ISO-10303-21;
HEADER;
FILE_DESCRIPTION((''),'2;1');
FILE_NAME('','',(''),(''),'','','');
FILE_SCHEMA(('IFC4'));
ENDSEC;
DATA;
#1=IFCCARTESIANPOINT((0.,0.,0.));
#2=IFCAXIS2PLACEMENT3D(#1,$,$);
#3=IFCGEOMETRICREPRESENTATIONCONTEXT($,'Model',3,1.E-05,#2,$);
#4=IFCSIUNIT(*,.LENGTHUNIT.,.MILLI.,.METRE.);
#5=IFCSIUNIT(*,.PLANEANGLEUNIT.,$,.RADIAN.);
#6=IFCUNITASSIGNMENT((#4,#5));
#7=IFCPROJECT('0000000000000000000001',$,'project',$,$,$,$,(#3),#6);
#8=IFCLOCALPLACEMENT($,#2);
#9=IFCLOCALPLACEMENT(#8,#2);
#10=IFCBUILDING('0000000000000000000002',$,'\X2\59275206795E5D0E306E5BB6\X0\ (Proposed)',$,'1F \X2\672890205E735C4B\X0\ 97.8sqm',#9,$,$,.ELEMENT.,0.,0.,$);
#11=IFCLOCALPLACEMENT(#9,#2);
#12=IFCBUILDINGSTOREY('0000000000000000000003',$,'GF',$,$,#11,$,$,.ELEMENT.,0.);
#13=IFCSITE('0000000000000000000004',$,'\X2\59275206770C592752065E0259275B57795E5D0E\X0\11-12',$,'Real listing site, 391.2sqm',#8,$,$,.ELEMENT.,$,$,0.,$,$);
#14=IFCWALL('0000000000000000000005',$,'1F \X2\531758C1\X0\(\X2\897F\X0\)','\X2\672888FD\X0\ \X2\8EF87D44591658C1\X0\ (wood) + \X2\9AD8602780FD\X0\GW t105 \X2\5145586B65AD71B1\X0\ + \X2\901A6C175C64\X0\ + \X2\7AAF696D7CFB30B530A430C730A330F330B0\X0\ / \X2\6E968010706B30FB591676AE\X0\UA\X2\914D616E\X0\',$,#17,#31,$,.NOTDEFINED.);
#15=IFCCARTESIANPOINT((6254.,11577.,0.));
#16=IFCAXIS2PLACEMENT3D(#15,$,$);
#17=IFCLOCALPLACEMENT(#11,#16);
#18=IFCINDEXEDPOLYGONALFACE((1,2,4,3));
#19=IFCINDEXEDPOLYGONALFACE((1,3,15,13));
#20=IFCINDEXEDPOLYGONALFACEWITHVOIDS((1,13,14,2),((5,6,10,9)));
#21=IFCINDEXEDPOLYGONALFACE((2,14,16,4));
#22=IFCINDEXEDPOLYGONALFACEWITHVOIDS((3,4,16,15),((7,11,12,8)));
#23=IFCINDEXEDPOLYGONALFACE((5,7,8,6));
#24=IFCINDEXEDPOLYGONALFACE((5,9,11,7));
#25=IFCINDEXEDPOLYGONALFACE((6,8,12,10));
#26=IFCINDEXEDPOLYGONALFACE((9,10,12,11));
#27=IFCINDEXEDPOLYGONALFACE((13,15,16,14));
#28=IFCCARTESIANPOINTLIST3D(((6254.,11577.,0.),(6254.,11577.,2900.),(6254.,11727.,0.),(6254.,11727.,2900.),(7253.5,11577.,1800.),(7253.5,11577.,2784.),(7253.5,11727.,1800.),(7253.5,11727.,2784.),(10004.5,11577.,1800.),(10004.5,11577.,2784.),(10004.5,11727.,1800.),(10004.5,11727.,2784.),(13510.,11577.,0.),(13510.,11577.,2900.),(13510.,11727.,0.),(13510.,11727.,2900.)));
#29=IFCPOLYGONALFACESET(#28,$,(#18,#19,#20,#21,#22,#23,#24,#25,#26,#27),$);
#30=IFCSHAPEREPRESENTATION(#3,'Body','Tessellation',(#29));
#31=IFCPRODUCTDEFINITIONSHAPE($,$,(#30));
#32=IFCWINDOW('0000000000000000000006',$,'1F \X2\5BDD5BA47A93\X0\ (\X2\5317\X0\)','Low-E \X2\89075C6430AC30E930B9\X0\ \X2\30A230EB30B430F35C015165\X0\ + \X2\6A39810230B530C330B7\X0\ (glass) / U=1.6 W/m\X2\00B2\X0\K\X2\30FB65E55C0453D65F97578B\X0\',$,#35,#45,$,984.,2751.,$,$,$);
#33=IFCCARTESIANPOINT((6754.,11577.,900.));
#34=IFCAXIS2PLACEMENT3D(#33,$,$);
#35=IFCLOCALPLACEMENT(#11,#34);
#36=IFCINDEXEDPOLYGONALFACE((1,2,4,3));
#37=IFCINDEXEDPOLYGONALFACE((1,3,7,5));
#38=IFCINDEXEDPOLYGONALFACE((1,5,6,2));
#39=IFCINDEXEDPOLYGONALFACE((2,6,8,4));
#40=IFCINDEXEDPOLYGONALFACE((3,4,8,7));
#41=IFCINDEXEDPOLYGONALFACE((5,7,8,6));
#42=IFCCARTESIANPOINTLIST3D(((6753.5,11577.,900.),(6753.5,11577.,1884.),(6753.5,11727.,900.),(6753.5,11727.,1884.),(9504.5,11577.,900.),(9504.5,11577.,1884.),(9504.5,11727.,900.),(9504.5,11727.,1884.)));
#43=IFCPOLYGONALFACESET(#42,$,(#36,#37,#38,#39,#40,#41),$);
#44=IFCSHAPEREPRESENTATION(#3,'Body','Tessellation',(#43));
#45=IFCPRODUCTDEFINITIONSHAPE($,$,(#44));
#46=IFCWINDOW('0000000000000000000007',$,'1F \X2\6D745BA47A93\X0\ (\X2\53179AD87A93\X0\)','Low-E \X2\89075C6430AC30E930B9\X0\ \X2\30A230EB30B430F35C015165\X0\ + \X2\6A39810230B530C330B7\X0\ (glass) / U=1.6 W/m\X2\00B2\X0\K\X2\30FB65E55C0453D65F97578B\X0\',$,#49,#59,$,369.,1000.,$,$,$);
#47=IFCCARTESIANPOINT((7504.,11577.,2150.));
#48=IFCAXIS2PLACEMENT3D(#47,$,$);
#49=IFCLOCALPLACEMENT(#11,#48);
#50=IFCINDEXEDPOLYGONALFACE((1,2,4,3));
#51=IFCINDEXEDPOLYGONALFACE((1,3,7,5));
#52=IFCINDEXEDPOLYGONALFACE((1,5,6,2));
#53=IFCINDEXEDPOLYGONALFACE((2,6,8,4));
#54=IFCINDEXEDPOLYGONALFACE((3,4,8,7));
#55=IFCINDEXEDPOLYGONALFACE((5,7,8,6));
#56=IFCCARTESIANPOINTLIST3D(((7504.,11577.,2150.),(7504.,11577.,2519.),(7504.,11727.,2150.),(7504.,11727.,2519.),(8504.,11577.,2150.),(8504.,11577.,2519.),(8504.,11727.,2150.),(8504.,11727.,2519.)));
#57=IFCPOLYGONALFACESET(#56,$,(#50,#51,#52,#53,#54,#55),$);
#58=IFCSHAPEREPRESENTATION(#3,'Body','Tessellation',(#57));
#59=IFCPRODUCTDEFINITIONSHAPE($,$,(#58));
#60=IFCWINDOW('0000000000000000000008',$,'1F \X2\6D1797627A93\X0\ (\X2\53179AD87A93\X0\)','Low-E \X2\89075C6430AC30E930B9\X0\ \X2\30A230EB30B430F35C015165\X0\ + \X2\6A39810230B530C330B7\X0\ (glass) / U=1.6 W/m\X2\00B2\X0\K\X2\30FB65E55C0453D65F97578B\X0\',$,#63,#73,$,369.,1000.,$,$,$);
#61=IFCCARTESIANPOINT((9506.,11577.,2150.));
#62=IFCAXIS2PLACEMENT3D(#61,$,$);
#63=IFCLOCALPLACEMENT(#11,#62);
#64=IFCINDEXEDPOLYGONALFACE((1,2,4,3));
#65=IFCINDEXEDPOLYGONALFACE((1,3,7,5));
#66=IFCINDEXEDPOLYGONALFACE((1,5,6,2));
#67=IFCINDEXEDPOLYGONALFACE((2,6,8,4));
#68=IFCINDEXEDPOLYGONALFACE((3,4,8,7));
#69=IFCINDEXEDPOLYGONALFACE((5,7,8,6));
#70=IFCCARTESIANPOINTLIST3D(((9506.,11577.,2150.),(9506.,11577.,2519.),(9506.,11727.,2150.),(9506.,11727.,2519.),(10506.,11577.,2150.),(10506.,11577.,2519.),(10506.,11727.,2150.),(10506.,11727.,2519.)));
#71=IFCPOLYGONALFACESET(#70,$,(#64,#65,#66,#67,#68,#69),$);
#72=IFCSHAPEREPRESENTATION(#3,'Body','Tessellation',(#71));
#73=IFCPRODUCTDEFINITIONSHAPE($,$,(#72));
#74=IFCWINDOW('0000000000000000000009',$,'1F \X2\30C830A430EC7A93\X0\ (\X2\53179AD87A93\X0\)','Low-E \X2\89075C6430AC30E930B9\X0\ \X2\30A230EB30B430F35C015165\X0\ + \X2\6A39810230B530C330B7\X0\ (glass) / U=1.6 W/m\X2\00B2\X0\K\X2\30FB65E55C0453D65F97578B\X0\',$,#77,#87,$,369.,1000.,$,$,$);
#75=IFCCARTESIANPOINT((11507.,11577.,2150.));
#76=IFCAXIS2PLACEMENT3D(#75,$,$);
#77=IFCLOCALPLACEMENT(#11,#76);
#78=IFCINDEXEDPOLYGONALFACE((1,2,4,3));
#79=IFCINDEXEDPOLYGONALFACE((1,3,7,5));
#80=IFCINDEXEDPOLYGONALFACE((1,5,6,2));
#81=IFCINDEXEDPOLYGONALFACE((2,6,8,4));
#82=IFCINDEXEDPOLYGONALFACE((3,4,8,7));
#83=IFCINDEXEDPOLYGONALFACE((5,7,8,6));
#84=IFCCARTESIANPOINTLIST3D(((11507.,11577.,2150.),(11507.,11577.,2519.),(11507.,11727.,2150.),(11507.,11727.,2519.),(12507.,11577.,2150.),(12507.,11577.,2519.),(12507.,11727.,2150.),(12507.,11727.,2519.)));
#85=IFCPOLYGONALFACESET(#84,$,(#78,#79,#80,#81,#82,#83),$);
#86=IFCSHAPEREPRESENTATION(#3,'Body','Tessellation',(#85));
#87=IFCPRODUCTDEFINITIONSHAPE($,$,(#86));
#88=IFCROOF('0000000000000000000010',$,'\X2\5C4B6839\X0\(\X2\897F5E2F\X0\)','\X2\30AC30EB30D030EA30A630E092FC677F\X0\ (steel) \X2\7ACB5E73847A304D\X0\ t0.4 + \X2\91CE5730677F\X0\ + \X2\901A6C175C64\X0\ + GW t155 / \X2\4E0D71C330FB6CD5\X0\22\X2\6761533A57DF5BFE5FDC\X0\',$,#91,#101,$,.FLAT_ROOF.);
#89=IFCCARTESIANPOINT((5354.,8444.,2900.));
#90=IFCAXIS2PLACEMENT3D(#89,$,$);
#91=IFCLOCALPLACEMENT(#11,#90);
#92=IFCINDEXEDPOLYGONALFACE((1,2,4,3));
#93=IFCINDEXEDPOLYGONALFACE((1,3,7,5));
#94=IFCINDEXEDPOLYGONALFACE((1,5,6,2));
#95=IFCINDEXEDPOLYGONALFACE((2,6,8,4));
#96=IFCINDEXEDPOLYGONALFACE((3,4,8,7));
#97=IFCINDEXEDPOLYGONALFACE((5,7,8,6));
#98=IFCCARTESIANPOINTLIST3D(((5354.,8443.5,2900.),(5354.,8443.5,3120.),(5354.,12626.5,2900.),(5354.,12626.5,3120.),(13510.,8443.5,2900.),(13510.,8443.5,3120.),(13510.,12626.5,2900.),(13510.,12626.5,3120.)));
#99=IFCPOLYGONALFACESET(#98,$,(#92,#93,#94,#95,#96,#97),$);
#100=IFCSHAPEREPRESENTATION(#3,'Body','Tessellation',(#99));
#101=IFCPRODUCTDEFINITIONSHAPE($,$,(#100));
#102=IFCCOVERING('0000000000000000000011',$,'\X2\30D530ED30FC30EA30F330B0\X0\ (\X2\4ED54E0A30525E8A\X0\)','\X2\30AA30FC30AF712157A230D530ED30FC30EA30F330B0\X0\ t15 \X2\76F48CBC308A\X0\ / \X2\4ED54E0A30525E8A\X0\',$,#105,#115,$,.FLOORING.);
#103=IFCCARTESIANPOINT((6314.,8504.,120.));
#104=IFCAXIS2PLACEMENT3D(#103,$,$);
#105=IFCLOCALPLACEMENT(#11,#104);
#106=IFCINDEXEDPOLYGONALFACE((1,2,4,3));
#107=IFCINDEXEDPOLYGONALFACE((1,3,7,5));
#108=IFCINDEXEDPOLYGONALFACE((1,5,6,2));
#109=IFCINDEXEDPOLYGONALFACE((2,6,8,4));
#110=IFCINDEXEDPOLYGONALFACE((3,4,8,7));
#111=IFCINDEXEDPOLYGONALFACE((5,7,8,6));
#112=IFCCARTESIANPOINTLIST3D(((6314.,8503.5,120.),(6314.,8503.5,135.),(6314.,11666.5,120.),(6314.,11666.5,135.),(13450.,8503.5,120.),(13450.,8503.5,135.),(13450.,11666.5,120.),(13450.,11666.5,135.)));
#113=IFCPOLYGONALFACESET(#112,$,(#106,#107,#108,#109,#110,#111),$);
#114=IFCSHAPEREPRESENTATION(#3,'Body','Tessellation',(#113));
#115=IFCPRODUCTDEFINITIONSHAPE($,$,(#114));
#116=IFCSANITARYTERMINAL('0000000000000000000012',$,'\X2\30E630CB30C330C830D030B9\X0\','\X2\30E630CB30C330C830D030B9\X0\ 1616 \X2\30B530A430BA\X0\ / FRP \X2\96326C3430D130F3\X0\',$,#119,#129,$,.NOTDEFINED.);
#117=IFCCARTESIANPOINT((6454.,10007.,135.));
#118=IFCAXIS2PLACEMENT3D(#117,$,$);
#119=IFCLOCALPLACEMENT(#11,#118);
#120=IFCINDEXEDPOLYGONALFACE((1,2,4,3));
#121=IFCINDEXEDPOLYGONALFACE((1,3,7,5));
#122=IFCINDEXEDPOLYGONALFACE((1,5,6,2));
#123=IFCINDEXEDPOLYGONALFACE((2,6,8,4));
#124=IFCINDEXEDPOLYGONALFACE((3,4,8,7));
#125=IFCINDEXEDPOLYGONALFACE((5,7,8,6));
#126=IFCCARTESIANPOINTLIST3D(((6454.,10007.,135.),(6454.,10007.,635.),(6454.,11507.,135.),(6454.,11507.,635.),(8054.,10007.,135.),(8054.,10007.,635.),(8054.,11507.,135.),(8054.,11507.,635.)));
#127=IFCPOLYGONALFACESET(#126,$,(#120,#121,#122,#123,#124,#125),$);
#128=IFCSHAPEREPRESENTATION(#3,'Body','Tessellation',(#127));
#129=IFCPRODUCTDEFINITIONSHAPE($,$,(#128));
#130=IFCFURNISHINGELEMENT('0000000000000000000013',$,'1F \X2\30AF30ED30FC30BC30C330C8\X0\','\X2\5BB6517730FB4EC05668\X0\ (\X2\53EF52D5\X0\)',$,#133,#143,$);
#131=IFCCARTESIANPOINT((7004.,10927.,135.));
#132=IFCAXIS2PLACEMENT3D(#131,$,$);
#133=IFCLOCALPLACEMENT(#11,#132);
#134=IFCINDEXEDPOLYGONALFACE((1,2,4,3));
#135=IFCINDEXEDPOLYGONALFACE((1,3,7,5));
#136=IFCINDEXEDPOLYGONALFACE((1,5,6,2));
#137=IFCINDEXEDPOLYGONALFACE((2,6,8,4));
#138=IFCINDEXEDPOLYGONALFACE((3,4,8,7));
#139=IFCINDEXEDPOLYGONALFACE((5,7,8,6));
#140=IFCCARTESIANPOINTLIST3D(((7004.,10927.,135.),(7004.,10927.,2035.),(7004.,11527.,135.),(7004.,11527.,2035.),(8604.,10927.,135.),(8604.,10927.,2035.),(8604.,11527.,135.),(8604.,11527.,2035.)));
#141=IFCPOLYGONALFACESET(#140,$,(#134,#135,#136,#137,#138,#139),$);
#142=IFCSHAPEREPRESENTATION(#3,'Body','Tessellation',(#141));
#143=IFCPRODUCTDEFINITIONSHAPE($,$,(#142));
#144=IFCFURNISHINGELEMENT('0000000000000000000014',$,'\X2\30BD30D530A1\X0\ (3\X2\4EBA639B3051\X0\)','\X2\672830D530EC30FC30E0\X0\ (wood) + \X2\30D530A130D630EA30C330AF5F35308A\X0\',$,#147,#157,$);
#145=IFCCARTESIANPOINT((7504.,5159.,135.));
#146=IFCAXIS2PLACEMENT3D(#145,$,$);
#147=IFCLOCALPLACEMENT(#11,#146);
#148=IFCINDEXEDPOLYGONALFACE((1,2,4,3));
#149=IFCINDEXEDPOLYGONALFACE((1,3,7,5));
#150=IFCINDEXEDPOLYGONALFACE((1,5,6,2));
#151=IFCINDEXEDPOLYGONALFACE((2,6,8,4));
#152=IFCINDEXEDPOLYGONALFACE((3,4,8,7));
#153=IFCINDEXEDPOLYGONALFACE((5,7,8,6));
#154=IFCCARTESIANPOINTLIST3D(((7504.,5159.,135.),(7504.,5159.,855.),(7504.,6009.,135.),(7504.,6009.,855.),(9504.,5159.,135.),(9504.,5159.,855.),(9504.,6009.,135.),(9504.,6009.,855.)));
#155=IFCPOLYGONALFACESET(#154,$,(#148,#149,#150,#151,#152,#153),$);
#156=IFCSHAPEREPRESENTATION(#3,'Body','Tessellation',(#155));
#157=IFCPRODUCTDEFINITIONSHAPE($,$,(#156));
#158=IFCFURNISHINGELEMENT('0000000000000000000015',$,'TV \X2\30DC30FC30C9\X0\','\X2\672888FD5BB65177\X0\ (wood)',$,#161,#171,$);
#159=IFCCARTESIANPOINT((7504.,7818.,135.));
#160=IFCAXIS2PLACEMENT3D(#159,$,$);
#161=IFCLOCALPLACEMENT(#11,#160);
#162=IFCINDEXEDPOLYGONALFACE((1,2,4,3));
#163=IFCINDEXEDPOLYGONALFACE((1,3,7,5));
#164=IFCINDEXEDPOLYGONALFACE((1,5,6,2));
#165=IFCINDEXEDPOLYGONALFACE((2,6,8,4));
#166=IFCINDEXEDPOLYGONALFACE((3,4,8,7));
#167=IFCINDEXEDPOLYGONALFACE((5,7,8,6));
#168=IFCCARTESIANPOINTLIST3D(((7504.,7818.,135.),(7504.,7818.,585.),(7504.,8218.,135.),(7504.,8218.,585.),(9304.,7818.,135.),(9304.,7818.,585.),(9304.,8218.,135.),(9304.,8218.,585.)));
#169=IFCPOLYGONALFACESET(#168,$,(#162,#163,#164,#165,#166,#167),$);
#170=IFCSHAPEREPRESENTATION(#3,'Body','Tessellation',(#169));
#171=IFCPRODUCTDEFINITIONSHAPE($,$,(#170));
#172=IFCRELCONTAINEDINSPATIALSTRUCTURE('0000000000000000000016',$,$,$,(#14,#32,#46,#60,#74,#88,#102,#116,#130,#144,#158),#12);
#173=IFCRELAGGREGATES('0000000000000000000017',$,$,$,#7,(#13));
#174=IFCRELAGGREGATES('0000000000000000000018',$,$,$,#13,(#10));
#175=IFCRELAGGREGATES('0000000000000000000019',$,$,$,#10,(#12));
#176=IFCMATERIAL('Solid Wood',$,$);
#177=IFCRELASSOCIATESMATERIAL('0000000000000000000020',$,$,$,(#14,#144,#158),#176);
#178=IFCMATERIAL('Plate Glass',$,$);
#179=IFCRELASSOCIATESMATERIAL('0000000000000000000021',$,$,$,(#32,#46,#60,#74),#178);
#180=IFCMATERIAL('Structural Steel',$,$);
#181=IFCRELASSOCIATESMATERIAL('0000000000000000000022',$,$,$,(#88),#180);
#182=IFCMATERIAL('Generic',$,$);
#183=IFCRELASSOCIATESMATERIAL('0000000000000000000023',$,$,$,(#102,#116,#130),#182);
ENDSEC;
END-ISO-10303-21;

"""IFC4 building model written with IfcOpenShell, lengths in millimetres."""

from ifc_helpers import new_model, si_unit, frame, frame_2d, origin, place, context, project, spatial, rectangle, extrude, material, element, fill, save


model = new_model("IFC4")

# Units and contexts
model_context = context("Model", 3, precision=1e-05, world=origin())
ifc_project = project(units=[si_unit("LENGTHUNIT", "METRE", prefix="MILLI"), si_unit("PLANEANGLEUNIT", "RADIAN")], contexts=[model_context])

# Site, building, storey
site_placement = place(None, origin())
site = spatial("IfcSite", under=ifc_project, at=site_placement, Name="大分県大分市大字神崎11-12", ObjectType="Real listing site, 391.2sqm", CompositionType="ELEMENT", RefElevation=0.0)
building_placement = place(site_placement, origin())
building = spatial("IfcBuilding", under=site, at=building_placement, Name="大分神崎の家 (Proposed)", ObjectType="1F 木造平屋 97.8sqm", CompositionType="ELEMENT", ElevationOfRefHeight=0.0, ElevationOfTerrain=0.0)
storey_placement = place(building_placement, origin())
storey = spatial("IfcBuildingStorey", under=building, at=storey_placement, Name="GF", CompositionType="ELEMENT", Elevation=0.0)

# Shared definitions
ifc_material_1 = material(Name="Solid Wood")

# Shared definitions
ifc_material_2 = material(Name="Plate Glass")

# Wall, openings, windows
wall_1_placement = place(storey_placement, frame((6254.0, 11577.0, 0.0)))
wall_1 = element("IfcWall", 1, at=wall_1_placement, inside=storey, material=ifc_material_1, Name="1F 北壁(西)", Description="木製 軸組外壁 (wood) + 高性能GW t105 充填断熱 + 通気層 + 窯業系サイディング / 準耐火・外皮UA配慮", PredefinedType="NOTDEFINED", context=model_context, shape_type="SweptSolid", body=[
    extrude(rectangle(XDim=7256.0, YDim=150.0, at=frame_2d((3628.0, 75.0))), frame((6254.0, 11577.0, 0.0)), (0.0, 0.0, 1.0), 2900.0),
])
opening_1_placement = place(storey_placement, frame((6754.0, 11577.0, 900.0)))
opening_1 = element("IfcOpeningElement", 2, at=opening_1_placement, cuts=wall_1, PredefinedType="NOTDEFINED", context=model_context, shape_type="SweptSolid", body=[
    extrude(rectangle(XDim=2751.0, YDim=150.0, at=frame_2d((1375.0, 75.0))), frame((6754.0, 11577.0, 900.0)), (0.0, 0.0, 1.0), 984.0),
])
opening_2_placement = place(storey_placement, frame((7504.0, 11577.0, 2150.0)))
opening_2 = element("IfcOpeningElement", 3, at=opening_2_placement, cuts=wall_1, PredefinedType="NOTDEFINED", context=model_context, shape_type="SweptSolid", body=[
    extrude(rectangle(XDim=1000.0, YDim=150.0, at=frame_2d((500.0, 75.0))), frame((7504.0, 11577.0, 2150.0)), (0.0, 0.0, 1.0), 369.0),
])
opening_3_placement = place(storey_placement, frame((9506.0, 11577.0, 2150.0)))
opening_3 = element("IfcOpeningElement", 4, at=opening_3_placement, cuts=wall_1, PredefinedType="NOTDEFINED", context=model_context, shape_type="SweptSolid", body=[
    extrude(rectangle(XDim=1000.0, YDim=150.0, at=frame_2d((500.0, 75.0))), frame((9506.0, 11577.0, 2150.0)), (0.0, 0.0, 1.0), 369.0),
])
opening_4_placement = place(storey_placement, frame((11507.0, 11577.0, 2150.0)))
opening_4 = element("IfcOpeningElement", 5, at=opening_4_placement, cuts=wall_1, PredefinedType="NOTDEFINED", context=model_context, shape_type="SweptSolid", body=[
    extrude(rectangle(XDim=1000.0, YDim=150.0, at=frame_2d((500.0, 75.0))), frame((11507.0, 11577.0, 2150.0)), (0.0, 0.0, 1.0), 369.0),
])
window_1_placement = place(storey_placement, frame((6754.0, 11577.0, 900.0)))
window_1 = element("IfcWindow", 6, at=window_1_placement, inside=storey, material=ifc_material_2, Name="1F 寝室窓 (北)", Description="Low-E 複層ガラス アルゴン封入 + 樹脂サッシ (glass) / U=1.6 W/m²K・日射取得型", OverallHeight=984.0, OverallWidth=2751.0, context=model_context, shape_type="SweptSolid", body=[
    extrude(rectangle(XDim=2751.0, YDim=150.0, at=frame_2d((1375.0, 75.0))), frame((6754.0, 11577.0, 900.0)), (0.0, 0.0, 1.0), 984.0),
])
fill(opening_1, window_1)
window_2_placement = place(storey_placement, frame((7504.0, 11577.0, 2150.0)))
window_2 = element("IfcWindow", 7, at=window_2_placement, inside=storey, material=ifc_material_2, Name="1F 浴室窓 (北高窓)", Description="Low-E 複層ガラス アルゴン封入 + 樹脂サッシ (glass) / U=1.6 W/m²K・日射取得型", OverallHeight=369.0, OverallWidth=1000.0, context=model_context, shape_type="SweptSolid", body=[
    extrude(rectangle(XDim=1000.0, YDim=150.0, at=frame_2d((500.0, 75.0))), frame((7504.0, 11577.0, 2150.0)), (0.0, 0.0, 1.0), 369.0),
])
fill(opening_2, window_2)
window_3_placement = place(storey_placement, frame((9506.0, 11577.0, 2150.0)))
window_3 = element("IfcWindow", 8, at=window_3_placement, inside=storey, material=ifc_material_2, Name="1F 洗面窓 (北高窓)", Description="Low-E 複層ガラス アルゴン封入 + 樹脂サッシ (glass) / U=1.6 W/m²K・日射取得型", OverallHeight=369.0, OverallWidth=1000.0, context=model_context, shape_type="SweptSolid", body=[
    extrude(rectangle(XDim=1000.0, YDim=150.0, at=frame_2d((500.0, 75.0))), frame((9506.0, 11577.0, 2150.0)), (0.0, 0.0, 1.0), 369.0),
])
fill(opening_3, window_3)
window_4_placement = place(storey_placement, frame((11507.0, 11577.0, 2150.0)))
window_4 = element("IfcWindow", 9, at=window_4_placement, inside=storey, material=ifc_material_2, Name="1F トイレ窓 (北高窓)", Description="Low-E 複層ガラス アルゴン封入 + 樹脂サッシ (glass) / U=1.6 W/m²K・日射取得型", OverallHeight=369.0, OverallWidth=1000.0, context=model_context, shape_type="SweptSolid", body=[
    extrude(rectangle(XDim=1000.0, YDim=150.0, at=frame_2d((500.0, 75.0))), frame((11507.0, 11577.0, 2150.0)), (0.0, 0.0, 1.0), 369.0),
])
fill(opening_4, window_4)

# Roof
ifc_material_3 = material(Name="Structural Steel")
roof_1_placement = place(storey_placement, frame((5354.0, 8444.0, 2900.0)))
element("IfcRoof", 10, at=roof_1_placement, inside=storey, material=ifc_material_3, Name="屋根(西帯)", Description="ガルバリウム鋼板 (steel) 立平葺き t0.4 + 野地板 + 通気層 + GW t155 / 不燃・法22条区域対応", PredefinedType="FLAT_ROOF", context=model_context, shape_type="SweptSolid", body=[
    extrude(rectangle(XDim=8156.0, YDim=4183.0, at=frame_2d((4078.0, 2091.0))), frame((5354.0, 8444.0, 2900.0)), (0.0, 0.0, 1.0), 220.0),
])

# Covering
ifc_material_4 = material(Name="Generic")
covering_1_placement = place(storey_placement, frame((6314.0, 8504.0, 120.0)))
element("IfcCovering", 11, at=covering_1_placement, inside=storey, material=ifc_material_4, Name="フローリング (仕上げ床)", Description="オーク無垢フローリング t15 直貼り / 仕上げ床", PredefinedType="FLOORING", context=model_context, shape_type="SweptSolid", body=[
    extrude(rectangle(XDim=7136.0, YDim=3163.0, at=frame_2d((3568.0, 1581.0))), frame((6314.0, 8504.0, 120.0)), (0.0, 0.0, 1.0), 15.0),
])

# Sanitary terminal
sanitary_terminal_placement = place(storey_placement, frame((6454.0, 10007.0, 135.0)))
element("IfcSanitaryTerminal", 12, at=sanitary_terminal_placement, inside=storey, material=ifc_material_4, Name="ユニットバス", Description="ユニットバス 1616 サイズ / FRP 防水パン", PredefinedType="NOTDEFINED", context=model_context, shape_type="SweptSolid", body=[
    extrude(rectangle(XDim=1600.0, YDim=1500.0, at=frame_2d((800.0, 750.0))), frame((6454.0, 10007.0, 135.0)), (0.0, 0.0, 1.0), 500.0),
])

# Furnishing elements
furnishing_1_placement = place(storey_placement, frame((7004.0, 10927.0, 135.0)))
element("IfcFurnishingElement", 13, at=furnishing_1_placement, inside=storey, material=ifc_material_4, Name="1F クローゼット", Description="家具・什器 (可動)", context=model_context, shape_type="SweptSolid", body=[
    extrude(rectangle(XDim=1600.0, YDim=600.0, at=frame_2d((800.0, 300.0))), frame((7004.0, 10927.0, 135.0)), (0.0, 0.0, 1.0), 1900.0),
])
furnishing_2_placement = place(storey_placement, frame((7504.0, 5159.0, 135.0)))
element("IfcFurnishingElement", 14, at=furnishing_2_placement, inside=storey, material=ifc_material_1, Name="ソファ (3人掛け)", Description="木フレーム (wood) + ファブリック張り", context=model_context, shape_type="SweptSolid", body=[
    extrude(rectangle(XDim=2000.0, YDim=850.0, at=frame_2d((1000.0, 425.0))), frame((7504.0, 5159.0, 135.0)), (0.0, 0.0, 1.0), 720.0),
])
furnishing_3_placement = place(storey_placement, frame((7504.0, 7818.0, 135.0)))
element("IfcFurnishingElement", 15, at=furnishing_3_placement, inside=storey, material=ifc_material_1, Name="TV ボード", Description="木製家具 (wood)", context=model_context, shape_type="SweptSolid", body=[
    extrude(rectangle(XDim=1800.0, YDim=400.0, at=frame_2d((900.0, 200.0))), frame((7504.0, 7818.0, 135.0)), (0.0, 0.0, 1.0), 450.0),
])

save(model, "model.ifc")
